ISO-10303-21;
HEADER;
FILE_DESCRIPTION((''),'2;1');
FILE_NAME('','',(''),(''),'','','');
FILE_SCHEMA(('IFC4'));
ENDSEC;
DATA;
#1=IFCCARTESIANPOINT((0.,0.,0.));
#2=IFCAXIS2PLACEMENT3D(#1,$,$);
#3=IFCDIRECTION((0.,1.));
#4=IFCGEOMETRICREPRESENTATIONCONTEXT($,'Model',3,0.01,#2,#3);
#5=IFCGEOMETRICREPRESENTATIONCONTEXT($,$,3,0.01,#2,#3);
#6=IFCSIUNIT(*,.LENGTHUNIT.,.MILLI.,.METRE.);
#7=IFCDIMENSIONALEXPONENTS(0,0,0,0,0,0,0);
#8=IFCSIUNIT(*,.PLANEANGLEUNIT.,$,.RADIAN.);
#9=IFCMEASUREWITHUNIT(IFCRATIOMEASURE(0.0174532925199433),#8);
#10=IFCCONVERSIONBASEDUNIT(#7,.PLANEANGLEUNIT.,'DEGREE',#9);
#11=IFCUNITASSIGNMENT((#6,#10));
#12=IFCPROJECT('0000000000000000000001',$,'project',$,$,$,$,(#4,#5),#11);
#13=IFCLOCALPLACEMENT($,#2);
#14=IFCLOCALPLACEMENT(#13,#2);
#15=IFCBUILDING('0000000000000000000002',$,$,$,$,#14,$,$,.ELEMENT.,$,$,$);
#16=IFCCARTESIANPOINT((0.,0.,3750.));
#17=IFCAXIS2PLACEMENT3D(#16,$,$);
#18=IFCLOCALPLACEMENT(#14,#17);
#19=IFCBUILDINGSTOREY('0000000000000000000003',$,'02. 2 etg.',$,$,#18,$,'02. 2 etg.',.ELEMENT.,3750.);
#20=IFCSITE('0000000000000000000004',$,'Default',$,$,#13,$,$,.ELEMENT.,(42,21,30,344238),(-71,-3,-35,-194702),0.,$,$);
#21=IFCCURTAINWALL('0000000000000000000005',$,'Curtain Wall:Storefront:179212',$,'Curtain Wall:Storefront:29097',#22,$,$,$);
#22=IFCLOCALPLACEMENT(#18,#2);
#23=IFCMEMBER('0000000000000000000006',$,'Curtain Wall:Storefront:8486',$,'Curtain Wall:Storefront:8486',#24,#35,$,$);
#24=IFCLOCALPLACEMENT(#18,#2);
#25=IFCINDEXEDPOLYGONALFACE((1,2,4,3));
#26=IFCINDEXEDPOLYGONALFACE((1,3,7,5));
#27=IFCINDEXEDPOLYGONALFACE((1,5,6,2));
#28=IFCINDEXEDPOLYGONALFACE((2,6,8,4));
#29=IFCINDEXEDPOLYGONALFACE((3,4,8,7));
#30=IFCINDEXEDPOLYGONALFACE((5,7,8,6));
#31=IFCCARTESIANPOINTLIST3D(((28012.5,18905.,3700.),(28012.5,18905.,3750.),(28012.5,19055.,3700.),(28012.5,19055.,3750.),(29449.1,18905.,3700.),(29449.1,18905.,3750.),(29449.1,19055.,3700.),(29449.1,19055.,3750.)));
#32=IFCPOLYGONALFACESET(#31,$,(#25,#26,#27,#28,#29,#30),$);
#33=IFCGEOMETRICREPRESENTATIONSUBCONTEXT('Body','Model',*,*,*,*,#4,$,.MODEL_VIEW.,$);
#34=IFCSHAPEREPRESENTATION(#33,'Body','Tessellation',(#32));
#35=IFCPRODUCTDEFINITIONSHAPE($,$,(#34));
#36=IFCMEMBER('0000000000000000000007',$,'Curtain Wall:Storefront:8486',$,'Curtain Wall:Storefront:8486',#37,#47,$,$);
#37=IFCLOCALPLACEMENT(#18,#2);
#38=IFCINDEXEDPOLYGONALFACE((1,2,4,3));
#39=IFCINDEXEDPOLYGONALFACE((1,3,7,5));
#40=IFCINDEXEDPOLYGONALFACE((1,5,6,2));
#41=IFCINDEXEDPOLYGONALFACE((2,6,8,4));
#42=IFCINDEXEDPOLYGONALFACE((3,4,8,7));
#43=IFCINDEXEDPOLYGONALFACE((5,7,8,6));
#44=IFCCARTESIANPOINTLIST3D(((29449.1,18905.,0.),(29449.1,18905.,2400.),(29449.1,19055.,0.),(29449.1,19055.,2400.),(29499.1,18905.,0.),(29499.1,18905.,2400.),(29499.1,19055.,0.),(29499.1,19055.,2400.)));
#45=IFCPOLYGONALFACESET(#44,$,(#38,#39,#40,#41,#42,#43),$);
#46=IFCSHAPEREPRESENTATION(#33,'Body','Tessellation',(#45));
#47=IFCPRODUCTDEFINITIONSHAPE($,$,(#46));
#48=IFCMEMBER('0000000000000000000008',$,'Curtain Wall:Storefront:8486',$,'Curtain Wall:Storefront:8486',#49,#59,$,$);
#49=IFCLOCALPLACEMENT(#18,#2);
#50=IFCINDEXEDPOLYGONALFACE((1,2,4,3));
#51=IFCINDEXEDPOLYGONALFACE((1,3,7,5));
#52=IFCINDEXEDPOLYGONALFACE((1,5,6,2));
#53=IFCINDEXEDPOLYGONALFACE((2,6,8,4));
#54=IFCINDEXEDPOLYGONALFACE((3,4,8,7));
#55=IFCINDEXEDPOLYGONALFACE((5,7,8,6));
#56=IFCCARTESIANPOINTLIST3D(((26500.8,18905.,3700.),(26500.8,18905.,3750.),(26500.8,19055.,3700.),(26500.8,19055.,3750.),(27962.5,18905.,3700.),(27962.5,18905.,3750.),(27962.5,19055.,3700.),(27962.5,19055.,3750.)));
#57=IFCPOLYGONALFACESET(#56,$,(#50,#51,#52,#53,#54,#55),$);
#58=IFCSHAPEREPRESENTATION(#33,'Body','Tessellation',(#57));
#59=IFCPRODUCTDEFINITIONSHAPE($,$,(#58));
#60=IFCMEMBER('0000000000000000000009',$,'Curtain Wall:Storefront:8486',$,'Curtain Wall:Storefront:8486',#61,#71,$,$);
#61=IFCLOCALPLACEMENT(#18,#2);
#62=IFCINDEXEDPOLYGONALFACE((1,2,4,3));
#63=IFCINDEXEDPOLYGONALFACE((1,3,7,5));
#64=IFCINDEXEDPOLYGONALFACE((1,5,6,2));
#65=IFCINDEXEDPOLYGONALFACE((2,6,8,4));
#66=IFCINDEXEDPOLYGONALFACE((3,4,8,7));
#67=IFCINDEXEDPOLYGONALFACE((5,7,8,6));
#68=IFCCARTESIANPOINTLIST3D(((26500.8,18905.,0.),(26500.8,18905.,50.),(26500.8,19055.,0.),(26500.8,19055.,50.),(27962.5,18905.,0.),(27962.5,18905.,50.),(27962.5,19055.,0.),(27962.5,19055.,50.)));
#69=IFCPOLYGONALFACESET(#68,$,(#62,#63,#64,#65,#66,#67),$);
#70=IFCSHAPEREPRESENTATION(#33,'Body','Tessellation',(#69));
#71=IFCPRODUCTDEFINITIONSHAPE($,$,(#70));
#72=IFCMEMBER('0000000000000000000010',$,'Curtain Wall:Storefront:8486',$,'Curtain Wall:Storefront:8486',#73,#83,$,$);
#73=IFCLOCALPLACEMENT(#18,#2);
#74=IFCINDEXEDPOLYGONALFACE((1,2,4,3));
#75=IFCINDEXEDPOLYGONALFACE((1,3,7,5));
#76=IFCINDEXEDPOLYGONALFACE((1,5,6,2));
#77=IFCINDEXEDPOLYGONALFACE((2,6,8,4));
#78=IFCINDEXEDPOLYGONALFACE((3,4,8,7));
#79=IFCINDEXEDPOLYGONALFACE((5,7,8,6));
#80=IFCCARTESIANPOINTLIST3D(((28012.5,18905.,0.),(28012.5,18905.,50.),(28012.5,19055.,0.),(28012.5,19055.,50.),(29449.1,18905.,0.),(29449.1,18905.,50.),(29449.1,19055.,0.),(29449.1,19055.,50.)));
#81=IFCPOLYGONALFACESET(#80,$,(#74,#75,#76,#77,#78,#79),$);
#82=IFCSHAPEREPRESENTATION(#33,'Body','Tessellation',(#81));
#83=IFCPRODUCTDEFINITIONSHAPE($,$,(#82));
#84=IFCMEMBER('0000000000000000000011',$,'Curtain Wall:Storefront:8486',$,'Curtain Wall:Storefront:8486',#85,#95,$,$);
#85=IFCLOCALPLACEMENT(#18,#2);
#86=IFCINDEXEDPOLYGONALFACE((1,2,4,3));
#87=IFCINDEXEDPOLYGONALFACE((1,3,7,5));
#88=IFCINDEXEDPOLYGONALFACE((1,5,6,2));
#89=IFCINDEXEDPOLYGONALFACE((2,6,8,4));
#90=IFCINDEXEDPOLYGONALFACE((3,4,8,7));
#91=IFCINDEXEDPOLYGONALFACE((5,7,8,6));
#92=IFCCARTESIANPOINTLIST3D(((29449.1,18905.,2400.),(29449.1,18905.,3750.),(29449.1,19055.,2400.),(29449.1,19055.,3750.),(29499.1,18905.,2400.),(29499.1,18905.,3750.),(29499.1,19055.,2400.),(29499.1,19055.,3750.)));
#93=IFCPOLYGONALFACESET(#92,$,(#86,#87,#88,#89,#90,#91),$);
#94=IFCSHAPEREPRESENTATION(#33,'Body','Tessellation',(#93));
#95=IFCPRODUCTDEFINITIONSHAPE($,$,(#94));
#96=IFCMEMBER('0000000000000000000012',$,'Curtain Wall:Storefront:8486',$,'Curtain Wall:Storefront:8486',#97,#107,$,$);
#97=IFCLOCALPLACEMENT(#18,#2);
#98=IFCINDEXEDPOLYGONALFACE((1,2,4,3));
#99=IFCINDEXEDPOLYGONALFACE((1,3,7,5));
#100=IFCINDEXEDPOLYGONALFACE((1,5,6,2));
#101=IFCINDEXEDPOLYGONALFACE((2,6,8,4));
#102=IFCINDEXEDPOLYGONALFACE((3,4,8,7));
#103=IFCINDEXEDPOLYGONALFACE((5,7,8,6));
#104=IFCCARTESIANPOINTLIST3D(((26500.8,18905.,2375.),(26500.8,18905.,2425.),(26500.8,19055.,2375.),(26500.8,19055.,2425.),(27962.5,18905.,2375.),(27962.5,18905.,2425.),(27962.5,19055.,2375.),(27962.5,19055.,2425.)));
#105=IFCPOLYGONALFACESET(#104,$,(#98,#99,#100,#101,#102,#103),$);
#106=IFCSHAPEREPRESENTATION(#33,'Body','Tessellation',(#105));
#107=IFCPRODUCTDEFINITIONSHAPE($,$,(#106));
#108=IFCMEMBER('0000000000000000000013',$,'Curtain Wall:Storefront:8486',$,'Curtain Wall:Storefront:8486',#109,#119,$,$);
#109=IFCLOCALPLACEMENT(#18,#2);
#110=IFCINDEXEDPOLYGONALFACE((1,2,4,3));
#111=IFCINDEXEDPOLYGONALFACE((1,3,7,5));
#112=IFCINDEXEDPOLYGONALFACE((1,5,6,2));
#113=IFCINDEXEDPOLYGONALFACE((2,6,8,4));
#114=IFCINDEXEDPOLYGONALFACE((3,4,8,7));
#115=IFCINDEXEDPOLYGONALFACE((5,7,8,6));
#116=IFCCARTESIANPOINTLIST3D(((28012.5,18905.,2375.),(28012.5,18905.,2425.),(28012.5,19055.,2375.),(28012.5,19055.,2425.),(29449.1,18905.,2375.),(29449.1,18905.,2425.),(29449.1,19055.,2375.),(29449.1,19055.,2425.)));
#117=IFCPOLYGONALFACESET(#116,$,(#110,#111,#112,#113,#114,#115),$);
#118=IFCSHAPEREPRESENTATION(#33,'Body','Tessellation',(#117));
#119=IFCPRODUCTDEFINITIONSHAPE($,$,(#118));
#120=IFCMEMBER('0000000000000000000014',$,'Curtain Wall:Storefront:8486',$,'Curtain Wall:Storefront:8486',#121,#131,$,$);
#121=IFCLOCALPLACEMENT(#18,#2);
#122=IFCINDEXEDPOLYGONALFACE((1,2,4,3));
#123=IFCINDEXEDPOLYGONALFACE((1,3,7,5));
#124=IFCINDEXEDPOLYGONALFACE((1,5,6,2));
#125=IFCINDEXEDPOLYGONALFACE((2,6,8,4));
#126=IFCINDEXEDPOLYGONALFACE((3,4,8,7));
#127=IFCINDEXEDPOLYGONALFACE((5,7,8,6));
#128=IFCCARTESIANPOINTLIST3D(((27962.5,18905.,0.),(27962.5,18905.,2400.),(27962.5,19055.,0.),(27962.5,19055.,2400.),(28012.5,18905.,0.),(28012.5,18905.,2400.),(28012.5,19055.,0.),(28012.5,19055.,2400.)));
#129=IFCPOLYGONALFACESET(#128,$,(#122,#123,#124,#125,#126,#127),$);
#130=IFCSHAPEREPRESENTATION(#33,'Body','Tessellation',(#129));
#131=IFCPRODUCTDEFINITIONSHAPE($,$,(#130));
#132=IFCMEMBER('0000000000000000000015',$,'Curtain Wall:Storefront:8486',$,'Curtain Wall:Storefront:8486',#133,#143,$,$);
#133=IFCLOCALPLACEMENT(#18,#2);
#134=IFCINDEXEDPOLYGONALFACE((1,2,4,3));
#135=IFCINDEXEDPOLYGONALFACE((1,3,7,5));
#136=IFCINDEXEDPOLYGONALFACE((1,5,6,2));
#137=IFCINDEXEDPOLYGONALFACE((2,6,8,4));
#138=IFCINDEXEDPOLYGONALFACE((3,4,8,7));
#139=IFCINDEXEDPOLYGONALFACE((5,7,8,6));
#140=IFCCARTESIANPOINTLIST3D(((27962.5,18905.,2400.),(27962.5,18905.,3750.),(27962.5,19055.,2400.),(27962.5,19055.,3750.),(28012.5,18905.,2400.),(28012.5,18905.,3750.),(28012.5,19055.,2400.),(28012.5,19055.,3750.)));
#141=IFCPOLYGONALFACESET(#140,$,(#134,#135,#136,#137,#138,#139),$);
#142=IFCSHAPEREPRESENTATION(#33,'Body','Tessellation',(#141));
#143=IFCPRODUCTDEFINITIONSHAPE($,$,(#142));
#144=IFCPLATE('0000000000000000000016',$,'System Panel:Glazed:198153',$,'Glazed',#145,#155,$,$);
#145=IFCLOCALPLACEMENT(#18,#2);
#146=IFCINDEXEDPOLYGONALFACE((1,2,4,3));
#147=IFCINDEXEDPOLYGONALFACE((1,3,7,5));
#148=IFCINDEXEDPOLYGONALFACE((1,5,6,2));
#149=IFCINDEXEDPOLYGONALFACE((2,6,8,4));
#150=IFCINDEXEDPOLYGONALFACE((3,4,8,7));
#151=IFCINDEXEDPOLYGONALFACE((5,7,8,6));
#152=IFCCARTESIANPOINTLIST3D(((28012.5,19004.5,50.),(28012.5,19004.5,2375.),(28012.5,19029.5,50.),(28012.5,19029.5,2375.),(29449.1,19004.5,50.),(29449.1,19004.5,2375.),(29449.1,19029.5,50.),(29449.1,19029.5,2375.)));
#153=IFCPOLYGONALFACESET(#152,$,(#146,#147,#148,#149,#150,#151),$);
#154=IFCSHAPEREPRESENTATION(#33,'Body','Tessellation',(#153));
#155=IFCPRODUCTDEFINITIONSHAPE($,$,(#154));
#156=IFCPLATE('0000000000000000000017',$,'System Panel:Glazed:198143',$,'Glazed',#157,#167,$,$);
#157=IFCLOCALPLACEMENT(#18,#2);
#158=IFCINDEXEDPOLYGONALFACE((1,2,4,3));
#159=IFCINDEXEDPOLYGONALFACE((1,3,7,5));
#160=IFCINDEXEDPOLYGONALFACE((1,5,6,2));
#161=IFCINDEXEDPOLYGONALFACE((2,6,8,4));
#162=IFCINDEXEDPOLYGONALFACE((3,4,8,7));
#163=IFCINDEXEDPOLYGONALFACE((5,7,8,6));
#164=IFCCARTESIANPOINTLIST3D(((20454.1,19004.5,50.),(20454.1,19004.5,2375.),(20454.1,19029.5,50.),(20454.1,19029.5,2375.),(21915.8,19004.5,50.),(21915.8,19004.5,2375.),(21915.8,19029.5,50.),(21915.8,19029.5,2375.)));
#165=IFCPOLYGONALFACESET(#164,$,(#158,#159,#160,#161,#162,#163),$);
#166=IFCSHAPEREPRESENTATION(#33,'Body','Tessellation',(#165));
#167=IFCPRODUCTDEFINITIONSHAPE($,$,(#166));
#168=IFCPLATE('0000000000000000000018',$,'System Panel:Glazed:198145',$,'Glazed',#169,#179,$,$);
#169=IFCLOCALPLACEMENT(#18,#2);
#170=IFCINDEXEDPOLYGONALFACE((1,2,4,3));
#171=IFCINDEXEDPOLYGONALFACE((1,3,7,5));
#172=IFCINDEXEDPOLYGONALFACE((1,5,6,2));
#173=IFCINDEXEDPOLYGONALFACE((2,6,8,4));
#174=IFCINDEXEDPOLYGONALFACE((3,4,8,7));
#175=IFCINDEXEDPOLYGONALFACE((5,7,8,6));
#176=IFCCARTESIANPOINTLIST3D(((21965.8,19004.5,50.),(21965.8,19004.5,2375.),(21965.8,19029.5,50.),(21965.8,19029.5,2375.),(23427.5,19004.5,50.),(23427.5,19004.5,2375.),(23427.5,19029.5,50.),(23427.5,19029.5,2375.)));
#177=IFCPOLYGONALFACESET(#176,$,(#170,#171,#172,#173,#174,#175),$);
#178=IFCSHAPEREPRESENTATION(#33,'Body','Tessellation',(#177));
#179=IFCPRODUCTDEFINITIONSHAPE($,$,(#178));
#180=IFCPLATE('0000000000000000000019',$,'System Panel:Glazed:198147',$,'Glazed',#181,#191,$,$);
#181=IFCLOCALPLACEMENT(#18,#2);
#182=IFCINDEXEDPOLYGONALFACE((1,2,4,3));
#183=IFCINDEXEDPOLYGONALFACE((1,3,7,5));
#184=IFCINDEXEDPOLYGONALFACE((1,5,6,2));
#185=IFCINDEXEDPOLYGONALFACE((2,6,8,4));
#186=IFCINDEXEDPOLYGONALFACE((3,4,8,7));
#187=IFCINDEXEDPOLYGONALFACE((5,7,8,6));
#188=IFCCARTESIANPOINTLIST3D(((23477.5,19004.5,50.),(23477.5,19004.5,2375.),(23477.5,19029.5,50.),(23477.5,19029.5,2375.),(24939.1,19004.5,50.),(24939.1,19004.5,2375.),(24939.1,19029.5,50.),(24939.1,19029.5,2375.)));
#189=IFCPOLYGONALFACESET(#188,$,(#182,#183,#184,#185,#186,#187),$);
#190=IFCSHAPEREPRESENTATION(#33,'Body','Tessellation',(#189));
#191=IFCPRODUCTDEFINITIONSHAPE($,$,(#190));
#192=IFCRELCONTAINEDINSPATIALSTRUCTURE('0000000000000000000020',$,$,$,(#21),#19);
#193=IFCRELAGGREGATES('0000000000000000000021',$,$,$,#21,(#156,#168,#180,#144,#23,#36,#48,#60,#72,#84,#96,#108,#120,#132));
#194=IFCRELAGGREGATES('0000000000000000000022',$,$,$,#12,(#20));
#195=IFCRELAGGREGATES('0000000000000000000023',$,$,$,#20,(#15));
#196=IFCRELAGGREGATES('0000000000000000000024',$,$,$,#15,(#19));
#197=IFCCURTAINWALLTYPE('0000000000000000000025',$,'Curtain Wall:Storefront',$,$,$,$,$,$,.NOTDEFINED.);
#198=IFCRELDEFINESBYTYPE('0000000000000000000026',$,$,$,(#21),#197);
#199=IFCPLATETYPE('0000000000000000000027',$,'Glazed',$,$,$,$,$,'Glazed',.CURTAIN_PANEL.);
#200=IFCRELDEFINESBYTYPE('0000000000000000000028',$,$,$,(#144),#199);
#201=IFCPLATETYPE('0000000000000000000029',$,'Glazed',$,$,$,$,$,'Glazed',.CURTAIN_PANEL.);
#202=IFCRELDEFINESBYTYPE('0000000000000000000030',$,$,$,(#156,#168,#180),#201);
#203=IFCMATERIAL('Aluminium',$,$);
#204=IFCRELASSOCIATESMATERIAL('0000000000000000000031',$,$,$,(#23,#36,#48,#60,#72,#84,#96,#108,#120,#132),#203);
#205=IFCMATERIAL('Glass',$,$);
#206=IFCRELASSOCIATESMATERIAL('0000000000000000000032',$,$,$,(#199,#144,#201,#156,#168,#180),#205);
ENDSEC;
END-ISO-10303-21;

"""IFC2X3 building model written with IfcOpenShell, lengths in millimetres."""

from ifc_helpers import new_model, entity, si_unit, converted_unit, direction, frame, frame_2d, origin, origin_2d_with_axis, place, context, subcontext, project, spatial, rectangle, extrude, source, transform, mapped, material, type_object, type_shapes, element, aggregate, save


model = new_model("IFC2X3")

# Units and contexts
model_context = context("Model", 3, precision=0.01, world=origin(), true_north=direction((0.0, 1.0)))
context_of_model = context(None, 3, precision=0.01, world=origin(), true_north=direction((0.0, 1.0)))
body_context = subcontext(model_context, "Body", "Model", "MODEL_VIEW")
ifc_project = project(units=[si_unit("LENGTHUNIT", "METRE", prefix="MILLI"), converted_unit("PLANEANGLEUNIT", "DEGREE", entity("IfcRatioMeasure", 0.0174532925199433), si_unit("PLANEANGLEUNIT", "RADIAN"), dimensions=[0, 0, 0, 0, 0, 0, 0])], contexts=[model_context, context_of_model])

# Site, building, storey
site_placement = place(None, origin())
site = spatial("IfcSite", under=ifc_project, at=site_placement, Name="Default", CompositionType="ELEMENT", RefLatitude=(42, 21, 30, 344238), RefLongitude=(-71, -3, -35, -194702), RefElevation=0.0)
building_placement = place(site_placement, origin())
building = spatial("IfcBuilding", under=site, at=building_placement, CompositionType="ELEMENT")
storey_placement = place(building_placement, frame((0.0, 0.0, 3750.0)))
storey = spatial("IfcBuildingStorey", under=building, at=storey_placement, Name="02. 2 etg.", LongName="02. 2 etg.", CompositionType="ELEMENT", Elevation=3750.0)

# Curtain wall, members, plates
curtain_wall_type = type_object("IfcCurtainWallType", Name="Curtain Wall:Storefront", PredefinedType="NOTDEFINED")
curtain_wall_placement = place(storey_placement, frame((0.0, 0.0, -3750.0)))
curtain_wall = element("IfcCurtainWall", 1, at=curtain_wall_placement, inside=storey, type_object=curtain_wall_type, Name="Curtain Wall:Storefront:179212", ObjectType="Curtain Wall:Storefront:29097")
ifc_material_1 = material(Name="Aluminium")
member_1_placement = place(curtain_wall_placement, frame((28012.5, 18905.0, 7450.0)))
member_1 = element("IfcMember", 2, at=member_1_placement, material=ifc_material_1, Name="Curtain Wall:Storefront:8486", ObjectType="Curtain Wall:Storefront:8486", context=body_context, shape_type="SweptSolid", body=[
    extrude(rectangle(XDim=1436.7, YDim=150.0, at=frame_2d((0.0, 0.0), x_axis=(1.0, 0.0))), frame((718.3, 75.0, 0.0), z_axis=(0.0, 0.0, 1.0), x_axis=(-1.0, 0.0, 0.0)), (0.0, 0.0, 1.0), 50.0),
])
member_2_placement = place(curtain_wall_placement, frame((29449.1, 18905.0, 3750.0)))
member_2 = element("IfcMember", 3, at=member_2_placement, material=ifc_material_1, Name="Curtain Wall:Storefront:8486", ObjectType="Curtain Wall:Storefront:8486", context=body_context, shape_type="SweptSolid", body=[
    extrude(rectangle(XDim=150.0, YDim=50.0, at=frame_2d((0.0, 0.0), x_axis=(1.0, 0.0))), frame((25.0, 75.0, 0.0), z_axis=(0.0, 0.0, 1.0), x_axis=(0.0, 1.0, 0.0)), (0.0, 0.0, 1.0), 2400.0),
])
member_3_placement = place(curtain_wall_placement, frame((26500.8, 18905.0, 7450.0)))
member_3 = element("IfcMember", 4, at=member_3_placement, material=ifc_material_1, Name="Curtain Wall:Storefront:8486", ObjectType="Curtain Wall:Storefront:8486", context=body_context, shape_type="SweptSolid", body=[
    extrude(rectangle(XDim=1461.7, YDim=150.0, at=origin_2d_with_axis()), frame((730.8, 75.0, 0.0), z_axis=(0.0, 0.0, 1.0), x_axis=(-1.0, 0.0, 0.0)), (0.0, 0.0, 1.0), 50.0),
])
member_4_placement = place(curtain_wall_placement, frame((26500.8, 18905.0, 3750.0)))
member_4 = element("IfcMember", 5, at=member_4_placement, material=ifc_material_1, Name="Curtain Wall:Storefront:8486", ObjectType="Curtain Wall:Storefront:8486", context=body_context, shape_type="SweptSolid", body=[
    extrude(rectangle(XDim=1461.7, YDim=150.0, at=origin_2d_with_axis()), frame((730.8, 75.0, 0.0)), (0.0, 0.0, 1.0), 50.0),
])
member_5_placement = place(curtain_wall_placement, frame((28012.5, 18905.0, 3750.0)))
member_5 = element("IfcMember", 6, at=member_5_placement, material=ifc_material_1, Name="Curtain Wall:Storefront:8486", ObjectType="Curtain Wall:Storefront:8486", context=body_context, shape_type="SweptSolid", body=[
    extrude(rectangle(XDim=1436.7, YDim=150.0, at=frame_2d((0.0, 0.0), x_axis=(1.0, 0.0))), frame((718.3, 75.0, 0.0)), (0.0, 0.0, 1.0), 50.0),
])
member_6_placement = place(curtain_wall_placement, frame((29449.1, 18905.0, 6150.0)))
member_6 = element("IfcMember", 7, at=member_6_placement, material=ifc_material_1, Name="Curtain Wall:Storefront:8486", ObjectType="Curtain Wall:Storefront:8486", context=body_context, shape_type="SweptSolid", body=[
    extrude(rectangle(XDim=150.0, YDim=50.0, at=origin_2d_with_axis()), frame((25.0, 75.0, 0.0), z_axis=(0.0, 0.0, 1.0), x_axis=(0.0, 1.0, 0.0)), (0.0, 0.0, 1.0), 1350.0),
])
member_7_placement = place(curtain_wall_placement, frame((26500.8, 18905.0, 6125.0)))
member_7 = element("IfcMember", 8, at=member_7_placement, material=ifc_material_1, Name="Curtain Wall:Storefront:8486", ObjectType="Curtain Wall:Storefront:8486", context=body_context, shape_type="SweptSolid", body=[
    extrude(rectangle(XDim=1461.7, YDim=150.0, at=frame_2d((0.0, 0.0), x_axis=(1.0, 0.0))), frame((730.8, 75.0, 0.0), z_axis=(0.0, 0.0, 1.0), x_axis=(-1.0, 0.0, 0.0)), (0.0, 0.0, 1.0), 50.0),
])
member_8_placement = place(curtain_wall_placement, frame((28012.5, 18905.0, 6125.0)))
member_8 = element("IfcMember", 9, at=member_8_placement, material=ifc_material_1, Name="Curtain Wall:Storefront:8486", ObjectType="Curtain Wall:Storefront:8486", context=body_context, shape_type="SweptSolid", body=[
    extrude(rectangle(XDim=1436.7, YDim=150.0, at=frame_2d((0.0, 0.0), x_axis=(1.0, 0.0))), frame((718.3, 75.0, 0.0), z_axis=(0.0, 0.0, 1.0), x_axis=(-1.0, 0.0, 0.0)), (0.0, 0.0, 1.0), 50.0),
])
member_9_placement = place(curtain_wall_placement, frame((27962.5, 18905.0, 3750.0)))
member_9 = element("IfcMember", 10, at=member_9_placement, material=ifc_material_1, Name="Curtain Wall:Storefront:8486", ObjectType="Curtain Wall:Storefront:8486", context=body_context, shape_type="SweptSolid", body=[
    extrude(rectangle(XDim=150.0, YDim=50.0, at=frame_2d((0.0, 0.0), x_axis=(1.0, 0.0))), frame((25.0, 75.0, 0.0), z_axis=(0.0, 0.0, 1.0), x_axis=(0.0, 1.0, 0.0)), (0.0, 0.0, 1.0), 2400.0),
])
member_10_placement = place(curtain_wall_placement, frame((27962.5, 18905.0, 6150.0)))
member_10 = element("IfcMember", 11, at=member_10_placement, material=ifc_material_1, Name="Curtain Wall:Storefront:8486", ObjectType="Curtain Wall:Storefront:8486", context=body_context, shape_type="SweptSolid", body=[
    extrude(rectangle(XDim=150.0, YDim=50.0, at=frame_2d((0.0, 0.0), x_axis=(1.0, 0.0))), frame((25.0, 75.0, 0.0), z_axis=(0.0, 0.0, 1.0), x_axis=(0.0, 1.0, 0.0)), (0.0, 0.0, 1.0), 1350.0),
])
ifc_material_2 = material(Name="Glass")
plate_type_1 = type_object("IfcPlateType", Name="Glazed", ElementType="Glazed", PredefinedType="CURTAIN_PANEL", material=ifc_material_2)
shared_shape_1 = source(origin(), body_context, "Body", "SweptSolid", [
    extrude(rectangle(XDim=25.0, YDim=1436.7, at=origin_2d_with_axis()), frame((718.3, 12.5, 0.0), z_axis=(0.0, 0.0, 1.0), x_axis=(0.0, 1.0, 0.0)), (0.0, 0.0, 1.0), 2325.0),
])
type_shapes(plate_type_1, [shared_shape_1])
plate_1_placement = place(curtain_wall_placement, frame((28012.5, 19004.5, 3800.0)))
plate_1 = element("IfcPlate", 12, at=plate_1_placement, type_object=plate_type_1, material=ifc_material_2, Name="System Panel:Glazed:198153", ObjectType="Glazed", context=body_context, shape_type="MappedRepresentation", body=[
    mapped(shared_shape_1, transform((0.0, 0.0, 0.0), scale=1.0)),
])
plate_type_2 = type_object("IfcPlateType", Name="Glazed", ElementType="Glazed", PredefinedType="CURTAIN_PANEL", material=ifc_material_2)
shared_shape_2 = source(origin(), body_context, "Body", "SweptSolid", [
    extrude(rectangle(XDim=25.0, YDim=1461.7, at=origin_2d_with_axis()), frame((730.8, 12.5, 0.0), z_axis=(0.0, 0.0, 1.0), x_axis=(0.0, 1.0, 0.0)), (0.0, 0.0, 1.0), 2325.0),
])
type_shapes(plate_type_2, [shared_shape_2])
plate_2_placement = place(curtain_wall_placement, frame((20454.1, 19004.5, 3800.0)))
plate_2 = element("IfcPlate", 13, at=plate_2_placement, type_object=plate_type_2, material=ifc_material_2, Name="System Panel:Glazed:198143", ObjectType="Glazed", context=body_context, shape_type="MappedRepresentation", body=[
    mapped(shared_shape_2, transform((0.0, 0.0, 0.0), scale=1.0)),
])
plate_3_placement = place(curtain_wall_placement, frame((21965.8, 19004.5, 3800.0)))
plate_3 = element("IfcPlate", 14, at=plate_3_placement, type_object=plate_type_2, material=ifc_material_2, Name="System Panel:Glazed:198145", ObjectType="Glazed", context=body_context, shape_type="MappedRepresentation", body=[
    mapped(shared_shape_2, transform((0.0, 0.0, 0.0), scale=1.0)),
])
plate_4_placement = place(curtain_wall_placement, frame((23477.5, 19004.5, 3800.0)))
plate_4 = element("IfcPlate", 15, at=plate_4_placement, type_object=plate_type_2, material=ifc_material_2, Name="System Panel:Glazed:198147", ObjectType="Glazed", context=body_context, shape_type="MappedRepresentation", body=[
    mapped(shared_shape_2, transform((0.0, 0.0, 0.0), scale=1.0)),
])
aggregate(curtain_wall, [plate_2, plate_3, plate_4, plate_1, member_1, member_2, member_3, member_4, member_5, member_6, member_7, member_8, member_9, member_10])

save(model, "model.ifc")
